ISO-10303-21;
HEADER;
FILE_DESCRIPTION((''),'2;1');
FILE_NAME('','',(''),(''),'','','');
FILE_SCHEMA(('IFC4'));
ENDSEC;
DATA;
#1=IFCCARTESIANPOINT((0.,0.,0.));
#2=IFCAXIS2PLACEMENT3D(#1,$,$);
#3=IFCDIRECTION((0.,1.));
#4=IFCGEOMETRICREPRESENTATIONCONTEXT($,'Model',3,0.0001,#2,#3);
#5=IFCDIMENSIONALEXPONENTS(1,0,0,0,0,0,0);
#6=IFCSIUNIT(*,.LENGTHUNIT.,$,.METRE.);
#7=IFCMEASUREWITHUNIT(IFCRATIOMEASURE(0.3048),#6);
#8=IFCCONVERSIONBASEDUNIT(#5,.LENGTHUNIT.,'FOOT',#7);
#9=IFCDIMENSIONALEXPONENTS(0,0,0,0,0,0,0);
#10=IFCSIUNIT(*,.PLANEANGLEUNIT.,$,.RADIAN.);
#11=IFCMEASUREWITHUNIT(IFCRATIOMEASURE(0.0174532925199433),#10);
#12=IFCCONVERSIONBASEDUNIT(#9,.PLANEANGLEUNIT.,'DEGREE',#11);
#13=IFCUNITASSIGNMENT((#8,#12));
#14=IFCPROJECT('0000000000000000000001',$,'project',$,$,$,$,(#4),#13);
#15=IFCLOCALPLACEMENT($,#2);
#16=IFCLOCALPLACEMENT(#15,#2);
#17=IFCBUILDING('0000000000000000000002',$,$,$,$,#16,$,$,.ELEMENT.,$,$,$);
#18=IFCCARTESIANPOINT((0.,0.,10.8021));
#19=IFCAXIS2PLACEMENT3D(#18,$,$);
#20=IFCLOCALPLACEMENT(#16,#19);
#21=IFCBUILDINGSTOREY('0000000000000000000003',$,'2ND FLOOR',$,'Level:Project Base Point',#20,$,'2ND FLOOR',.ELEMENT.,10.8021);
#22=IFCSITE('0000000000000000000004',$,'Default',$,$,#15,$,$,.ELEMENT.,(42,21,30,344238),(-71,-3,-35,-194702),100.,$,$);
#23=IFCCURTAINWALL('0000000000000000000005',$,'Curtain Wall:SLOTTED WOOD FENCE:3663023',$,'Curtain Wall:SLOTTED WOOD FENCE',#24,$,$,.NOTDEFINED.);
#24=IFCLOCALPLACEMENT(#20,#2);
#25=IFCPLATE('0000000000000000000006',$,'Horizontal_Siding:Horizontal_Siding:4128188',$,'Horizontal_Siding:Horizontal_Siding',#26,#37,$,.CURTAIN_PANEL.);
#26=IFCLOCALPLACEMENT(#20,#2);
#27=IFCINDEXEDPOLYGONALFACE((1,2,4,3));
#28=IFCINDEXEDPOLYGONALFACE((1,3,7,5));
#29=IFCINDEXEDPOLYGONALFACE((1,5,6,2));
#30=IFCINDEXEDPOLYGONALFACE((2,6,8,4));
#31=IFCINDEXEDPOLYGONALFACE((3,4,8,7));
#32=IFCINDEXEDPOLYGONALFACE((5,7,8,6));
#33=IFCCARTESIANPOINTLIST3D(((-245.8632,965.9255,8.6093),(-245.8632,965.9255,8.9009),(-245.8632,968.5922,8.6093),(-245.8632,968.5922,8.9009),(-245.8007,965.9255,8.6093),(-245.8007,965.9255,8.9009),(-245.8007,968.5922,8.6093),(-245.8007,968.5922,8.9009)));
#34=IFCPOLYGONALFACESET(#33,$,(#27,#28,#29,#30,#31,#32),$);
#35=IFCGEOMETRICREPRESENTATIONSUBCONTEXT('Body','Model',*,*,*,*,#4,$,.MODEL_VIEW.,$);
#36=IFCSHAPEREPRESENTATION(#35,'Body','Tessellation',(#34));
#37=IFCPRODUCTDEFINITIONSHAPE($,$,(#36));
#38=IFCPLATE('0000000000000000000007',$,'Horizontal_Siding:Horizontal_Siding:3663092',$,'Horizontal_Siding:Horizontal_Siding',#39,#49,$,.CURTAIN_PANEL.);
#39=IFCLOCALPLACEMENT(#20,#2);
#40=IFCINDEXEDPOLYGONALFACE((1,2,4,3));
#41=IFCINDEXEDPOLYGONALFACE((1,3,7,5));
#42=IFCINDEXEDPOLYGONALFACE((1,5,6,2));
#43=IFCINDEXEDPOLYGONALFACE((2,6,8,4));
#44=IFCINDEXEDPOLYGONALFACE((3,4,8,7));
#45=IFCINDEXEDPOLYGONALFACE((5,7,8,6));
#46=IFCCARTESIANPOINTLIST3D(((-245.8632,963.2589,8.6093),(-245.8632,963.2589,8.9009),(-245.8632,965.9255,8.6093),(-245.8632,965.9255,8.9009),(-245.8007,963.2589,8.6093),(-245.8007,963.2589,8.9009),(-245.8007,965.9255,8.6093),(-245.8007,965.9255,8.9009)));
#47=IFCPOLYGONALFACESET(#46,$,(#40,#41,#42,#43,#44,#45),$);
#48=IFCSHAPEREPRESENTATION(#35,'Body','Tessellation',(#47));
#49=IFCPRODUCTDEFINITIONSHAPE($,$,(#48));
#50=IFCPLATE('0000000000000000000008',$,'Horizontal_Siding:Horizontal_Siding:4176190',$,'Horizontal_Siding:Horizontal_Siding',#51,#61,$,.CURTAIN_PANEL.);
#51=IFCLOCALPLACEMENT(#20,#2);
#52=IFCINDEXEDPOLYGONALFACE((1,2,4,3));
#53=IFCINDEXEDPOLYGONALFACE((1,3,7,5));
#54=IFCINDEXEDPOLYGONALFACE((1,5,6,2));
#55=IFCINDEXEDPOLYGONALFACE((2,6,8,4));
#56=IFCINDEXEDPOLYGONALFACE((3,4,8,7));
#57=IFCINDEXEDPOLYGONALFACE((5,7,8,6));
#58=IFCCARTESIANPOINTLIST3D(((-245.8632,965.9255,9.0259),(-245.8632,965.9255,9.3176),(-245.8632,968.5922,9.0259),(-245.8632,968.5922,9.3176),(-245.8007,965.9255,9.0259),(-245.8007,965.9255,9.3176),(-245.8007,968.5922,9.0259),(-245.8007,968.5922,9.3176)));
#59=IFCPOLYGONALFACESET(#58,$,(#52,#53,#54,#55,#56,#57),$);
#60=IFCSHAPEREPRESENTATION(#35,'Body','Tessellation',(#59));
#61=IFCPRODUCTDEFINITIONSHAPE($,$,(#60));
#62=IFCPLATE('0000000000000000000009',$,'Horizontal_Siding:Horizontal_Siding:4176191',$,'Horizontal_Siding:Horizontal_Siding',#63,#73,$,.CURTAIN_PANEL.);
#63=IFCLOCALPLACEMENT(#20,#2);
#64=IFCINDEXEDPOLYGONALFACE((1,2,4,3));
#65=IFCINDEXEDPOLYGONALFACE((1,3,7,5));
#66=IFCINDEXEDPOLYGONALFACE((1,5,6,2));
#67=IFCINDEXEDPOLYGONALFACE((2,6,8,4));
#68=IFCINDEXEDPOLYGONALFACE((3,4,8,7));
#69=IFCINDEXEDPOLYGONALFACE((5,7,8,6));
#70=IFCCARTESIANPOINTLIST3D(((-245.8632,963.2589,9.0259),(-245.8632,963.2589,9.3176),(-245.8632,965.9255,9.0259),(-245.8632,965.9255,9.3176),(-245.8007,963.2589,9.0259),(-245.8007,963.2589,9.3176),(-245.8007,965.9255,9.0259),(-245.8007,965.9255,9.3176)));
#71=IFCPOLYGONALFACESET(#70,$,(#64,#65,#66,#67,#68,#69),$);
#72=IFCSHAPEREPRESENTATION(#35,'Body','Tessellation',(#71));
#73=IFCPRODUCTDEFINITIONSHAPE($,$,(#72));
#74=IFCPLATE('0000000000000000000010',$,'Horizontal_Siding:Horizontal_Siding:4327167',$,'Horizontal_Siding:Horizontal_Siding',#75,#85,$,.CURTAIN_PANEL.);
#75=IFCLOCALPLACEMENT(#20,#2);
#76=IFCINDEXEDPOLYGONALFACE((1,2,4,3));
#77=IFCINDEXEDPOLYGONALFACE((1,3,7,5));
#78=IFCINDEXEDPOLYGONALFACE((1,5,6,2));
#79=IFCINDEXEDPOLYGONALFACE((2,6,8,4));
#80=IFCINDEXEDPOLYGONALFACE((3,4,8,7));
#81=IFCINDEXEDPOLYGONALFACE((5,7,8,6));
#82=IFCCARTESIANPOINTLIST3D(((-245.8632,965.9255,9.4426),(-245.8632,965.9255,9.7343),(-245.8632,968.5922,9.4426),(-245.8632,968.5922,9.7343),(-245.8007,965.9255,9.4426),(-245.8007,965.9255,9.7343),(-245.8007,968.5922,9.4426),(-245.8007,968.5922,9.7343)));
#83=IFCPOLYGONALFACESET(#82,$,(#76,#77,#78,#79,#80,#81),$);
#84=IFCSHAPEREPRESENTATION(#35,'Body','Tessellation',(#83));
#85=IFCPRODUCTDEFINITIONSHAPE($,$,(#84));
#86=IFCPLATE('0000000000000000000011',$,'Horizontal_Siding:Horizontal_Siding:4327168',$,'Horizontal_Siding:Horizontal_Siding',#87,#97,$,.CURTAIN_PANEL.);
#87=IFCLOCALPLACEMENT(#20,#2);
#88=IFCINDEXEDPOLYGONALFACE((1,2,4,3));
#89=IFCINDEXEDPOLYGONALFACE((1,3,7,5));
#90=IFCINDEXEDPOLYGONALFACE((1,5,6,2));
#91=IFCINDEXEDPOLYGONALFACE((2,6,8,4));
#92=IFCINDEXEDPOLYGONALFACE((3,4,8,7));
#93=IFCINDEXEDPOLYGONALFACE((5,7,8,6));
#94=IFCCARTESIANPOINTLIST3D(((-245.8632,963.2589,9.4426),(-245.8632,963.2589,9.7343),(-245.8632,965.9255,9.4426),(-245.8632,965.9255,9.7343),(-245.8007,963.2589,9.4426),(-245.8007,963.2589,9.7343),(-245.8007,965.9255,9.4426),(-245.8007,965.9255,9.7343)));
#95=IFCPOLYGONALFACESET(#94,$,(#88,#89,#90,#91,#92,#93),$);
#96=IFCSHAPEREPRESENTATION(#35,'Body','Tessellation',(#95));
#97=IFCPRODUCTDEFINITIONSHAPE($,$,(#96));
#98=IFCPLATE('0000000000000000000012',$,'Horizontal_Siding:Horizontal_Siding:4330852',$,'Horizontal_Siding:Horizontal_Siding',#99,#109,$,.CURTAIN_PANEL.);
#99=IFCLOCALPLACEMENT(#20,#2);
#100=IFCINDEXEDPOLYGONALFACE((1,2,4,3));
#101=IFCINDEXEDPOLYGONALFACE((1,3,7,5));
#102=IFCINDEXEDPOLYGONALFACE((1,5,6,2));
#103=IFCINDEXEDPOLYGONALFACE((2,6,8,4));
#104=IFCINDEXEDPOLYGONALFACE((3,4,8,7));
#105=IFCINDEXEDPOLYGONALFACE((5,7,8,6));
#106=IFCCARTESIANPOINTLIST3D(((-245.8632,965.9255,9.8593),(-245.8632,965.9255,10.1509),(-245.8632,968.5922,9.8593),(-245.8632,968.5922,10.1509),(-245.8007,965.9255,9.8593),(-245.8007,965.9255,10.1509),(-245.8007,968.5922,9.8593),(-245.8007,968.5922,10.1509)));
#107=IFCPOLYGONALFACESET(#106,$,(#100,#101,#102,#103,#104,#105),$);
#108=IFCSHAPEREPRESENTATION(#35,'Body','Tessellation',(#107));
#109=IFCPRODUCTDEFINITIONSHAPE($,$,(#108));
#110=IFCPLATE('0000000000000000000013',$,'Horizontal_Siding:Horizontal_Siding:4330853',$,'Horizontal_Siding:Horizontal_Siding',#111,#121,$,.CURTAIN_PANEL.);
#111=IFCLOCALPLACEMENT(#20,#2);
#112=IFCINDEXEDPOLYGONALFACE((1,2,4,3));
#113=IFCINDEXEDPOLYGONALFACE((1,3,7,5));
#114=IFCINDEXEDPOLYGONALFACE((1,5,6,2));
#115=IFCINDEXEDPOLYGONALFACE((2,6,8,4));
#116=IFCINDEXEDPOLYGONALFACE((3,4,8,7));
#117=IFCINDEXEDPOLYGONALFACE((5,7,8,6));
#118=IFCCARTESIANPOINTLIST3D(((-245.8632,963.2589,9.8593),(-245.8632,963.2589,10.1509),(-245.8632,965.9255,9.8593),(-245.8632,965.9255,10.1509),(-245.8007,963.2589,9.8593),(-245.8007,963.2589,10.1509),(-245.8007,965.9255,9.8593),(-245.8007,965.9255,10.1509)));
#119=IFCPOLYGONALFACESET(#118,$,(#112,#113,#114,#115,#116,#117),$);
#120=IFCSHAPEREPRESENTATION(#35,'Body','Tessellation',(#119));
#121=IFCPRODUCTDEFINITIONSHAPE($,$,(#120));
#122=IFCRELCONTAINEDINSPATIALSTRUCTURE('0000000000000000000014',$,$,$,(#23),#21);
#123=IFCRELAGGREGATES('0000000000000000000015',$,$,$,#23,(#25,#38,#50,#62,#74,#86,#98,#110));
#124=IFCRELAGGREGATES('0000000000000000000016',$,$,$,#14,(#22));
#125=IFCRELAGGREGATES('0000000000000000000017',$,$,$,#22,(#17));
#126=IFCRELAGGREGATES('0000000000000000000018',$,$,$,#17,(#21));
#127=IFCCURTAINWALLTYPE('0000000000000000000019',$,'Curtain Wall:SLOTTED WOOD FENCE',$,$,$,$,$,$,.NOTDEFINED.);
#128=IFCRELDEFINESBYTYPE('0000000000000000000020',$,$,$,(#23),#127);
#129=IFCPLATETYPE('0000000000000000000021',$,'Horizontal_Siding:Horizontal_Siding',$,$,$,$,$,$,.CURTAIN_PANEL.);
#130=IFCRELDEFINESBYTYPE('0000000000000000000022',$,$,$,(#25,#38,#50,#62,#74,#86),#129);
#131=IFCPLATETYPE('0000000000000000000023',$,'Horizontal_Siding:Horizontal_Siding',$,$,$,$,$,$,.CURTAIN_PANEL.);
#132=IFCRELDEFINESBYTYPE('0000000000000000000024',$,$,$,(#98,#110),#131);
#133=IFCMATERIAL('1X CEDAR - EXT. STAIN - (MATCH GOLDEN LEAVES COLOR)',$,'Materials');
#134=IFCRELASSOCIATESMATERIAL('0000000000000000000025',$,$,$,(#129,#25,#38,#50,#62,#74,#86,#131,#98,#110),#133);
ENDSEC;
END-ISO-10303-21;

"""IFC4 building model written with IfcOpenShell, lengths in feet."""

from ifc_helpers import new_model, entity, si_unit, converted_unit, direction, frame, origin, origin_2d_with_axis, place, context, subcontext, project, spatial, rectangle, extrude, source, transform, mapped, material, type_object, type_shapes, element, aggregate, save


model = new_model("IFC4")

# Units and contexts
model_context = context("Model", 3, precision=0.0001, world=origin(), true_north=direction((0.0, 1.0)))
body_context = subcontext(model_context, "Body", "Model", "MODEL_VIEW")
ifc_project = project(units=[converted_unit("LENGTHUNIT", "FOOT", entity("IfcRatioMeasure", 0.3048), si_unit("LENGTHUNIT", "METRE"), dimensions=[1, 0, 0, 0, 0, 0, 0]), converted_unit("PLANEANGLEUNIT", "DEGREE", entity("IfcRatioMeasure", 0.0174532925199433), si_unit("PLANEANGLEUNIT", "RADIAN"), dimensions=[0, 0, 0, 0, 0, 0, 0])], contexts=[model_context])

# Site, building, storey
site_placement = place(None, origin())
site = spatial("IfcSite", under=ifc_project, at=site_placement, Name="Default", CompositionType="ELEMENT", RefLatitude=(42, 21, 30, 344238), RefLongitude=(-71, -3, -35, -194702), RefElevation=100.0)
building_placement = place(site_placement, origin())
building = spatial("IfcBuilding", under=site, at=building_placement, CompositionType="ELEMENT")
storey_placement = place(building_placement, frame((0.0, 0.0, 10.8021)))
storey = spatial("IfcBuildingStorey", under=building, at=storey_placement, Name="2ND FLOOR", ObjectType="Level:Project Base Point", LongName="2ND FLOOR", CompositionType="ELEMENT", Elevation=10.8021)

# Curtain wall, plates
curtain_wall_type = type_object("IfcCurtainWallType", Name="Curtain Wall:SLOTTED WOOD FENCE", PredefinedType="NOTDEFINED")
curtain_wall_placement = place(storey_placement, frame((0.0, 0.0, -10.8021)))
curtain_wall = element("IfcCurtainWall", 1, at=curtain_wall_placement, inside=storey, type_object=curtain_wall_type, Name="Curtain Wall:SLOTTED WOOD FENCE:3663023", ObjectType="Curtain Wall:SLOTTED WOOD FENCE", PredefinedType="NOTDEFINED")
ifc_material_1 = material(Name="1X CEDAR - EXT. STAIN - (MATCH GOLDEN LEAVES COLOR)", Category="Materials")
plate_type_1 = type_object("IfcPlateType", Name="Horizontal_Siding:Horizontal_Siding", PredefinedType="CURTAIN_PANEL", material=ifc_material_1)
shared_shape_1 = source(origin(), body_context, "Body", "SweptSolid", [
    extrude(rectangle(XDim=0.0625, YDim=2.6667, at=origin_2d_with_axis()), frame((1.3333, 0.0312, 0.0), z_axis=(0.0, 0.0, 1.0), x_axis=(0.0, 1.0, 0.0)), (0.0, 0.0, 1.0), 0.2917),
])
type_shapes(plate_type_1, [shared_shape_1])
plate_1_placement = place(curtain_wall_placement, frame((-245.8632, 968.5922, 19.4113), z_axis=(0.0, 0.0, 1.0), x_axis=(0.0, -1.0, 0.0)))
plate_1 = element("IfcPlate", 2, at=plate_1_placement, type_object=plate_type_1, material=ifc_material_1, Name="Horizontal_Siding:Horizontal_Siding:4128188", ObjectType="Horizontal_Siding:Horizontal_Siding", PredefinedType="CURTAIN_PANEL", context=body_context, shape_type="MappedRepresentation", body=[
    mapped(shared_shape_1, transform((0.0, 0.0, 0.0), scale=1.0)),
])
plate_2_placement = place(curtain_wall_placement, frame((-245.8632, 965.9255, 19.4113), z_axis=(0.0, 0.0, 1.0), x_axis=(0.0, -1.0, 0.0)))
plate_2 = element("IfcPlate", 3, at=plate_2_placement, type_object=plate_type_1, material=ifc_material_1, Name="Horizontal_Siding:Horizontal_Siding:3663092", ObjectType="Horizontal_Siding:Horizontal_Siding", PredefinedType="CURTAIN_PANEL", context=body_context, shape_type="MappedRepresentation", body=[
    mapped(shared_shape_1, transform((0.0, 0.0, 0.0), scale=1.0)),
])
plate_3_placement = place(curtain_wall_placement, frame((-245.8632, 968.5922, 19.828), z_axis=(0.0, 0.0, 1.0), x_axis=(0.0, -1.0, 0.0)))
plate_3 = element("IfcPlate", 4, at=plate_3_placement, type_object=plate_type_1, material=ifc_material_1, Name="Horizontal_Siding:Horizontal_Siding:4176190", ObjectType="Horizontal_Siding:Horizontal_Siding", PredefinedType="CURTAIN_PANEL", context=body_context, shape_type="MappedRepresentation", body=[
    mapped(shared_shape_1, transform((0.0, 0.0, 0.0), scale=1.0)),
])
plate_4_placement = place(curtain_wall_placement, frame((-245.8632, 965.9255, 19.828), z_axis=(0.0, 0.0, 1.0), x_axis=(0.0, -1.0, 0.0)))
plate_4 = element("IfcPlate", 5, at=plate_4_placement, type_object=plate_type_1, material=ifc_material_1, Name="Horizontal_Siding:Horizontal_Siding:4176191", ObjectType="Horizontal_Siding:Horizontal_Siding", PredefinedType="CURTAIN_PANEL", context=body_context, shape_type="MappedRepresentation", body=[
    mapped(shared_shape_1, transform((0.0, 0.0, 0.0), scale=1.0)),
])
plate_5_placement = place(curtain_wall_placement, frame((-245.8632, 968.5922, 20.2447), z_axis=(0.0, 0.0, 1.0), x_axis=(0.0, -1.0, 0.0)))
plate_5 = element("IfcPlate", 6, at=plate_5_placement, type_object=plate_type_1, material=ifc_material_1, Name="Horizontal_Siding:Horizontal_Siding:4327167", ObjectType="Horizontal_Siding:Horizontal_Siding", PredefinedType="CURTAIN_PANEL", context=body_context, shape_type="MappedRepresentation", body=[
    mapped(shared_shape_1, transform((0.0, 0.0, 0.0), scale=1.0)),
])
plate_6_placement = place(curtain_wall_placement, frame((-245.8632, 965.9255, 20.2447), z_axis=(0.0, 0.0, 1.0), x_axis=(0.0, -1.0, 0.0)))
plate_6 = element("IfcPlate", 7, at=plate_6_placement, type_object=plate_type_1, material=ifc_material_1, Name="Horizontal_Siding:Horizontal_Siding:4327168", ObjectType="Horizontal_Siding:Horizontal_Siding", PredefinedType="CURTAIN_PANEL", context=body_context, shape_type="MappedRepresentation", body=[
    mapped(shared_shape_1, transform((0.0, 0.0, 0.0), scale=1.0)),
])
plate_type_2 = type_object("IfcPlateType", Name="Horizontal_Siding:Horizontal_Siding", PredefinedType="CURTAIN_PANEL", material=ifc_material_1)
shared_shape_2 = source(origin(), body_context, "Body", "SweptSolid", [
    extrude(rectangle(XDim=0.0625, YDim=2.6667, at=origin_2d_with_axis()), frame((1.3333, 0.0312, 0.0), z_axis=(0.0, 0.0, 1.0), x_axis=(0.0, 1.0, 0.0)), (0.0, 0.0, 1.0), 0.2917),
])
type_shapes(plate_type_2, [shared_shape_2])
plate_7_placement = place(curtain_wall_placement, frame((-245.8632, 968.5922, 20.6613), z_axis=(0.0, 0.0, 1.0), x_axis=(0.0, -1.0, 0.0)))
plate_7 = element("IfcPlate", 8, at=plate_7_placement, type_object=plate_type_2, material=ifc_material_1, Name="Horizontal_Siding:Horizontal_Siding:4330852", ObjectType="Horizontal_Siding:Horizontal_Siding", PredefinedType="CURTAIN_PANEL", context=body_context, shape_type="MappedRepresentation", body=[
    mapped(shared_shape_2, transform((0.0, 0.0, 0.0), scale=1.0)),
])
plate_8_placement = place(curtain_wall_placement, frame((-245.8632, 965.9255, 20.6613), z_axis=(0.0, 0.0, 1.0), x_axis=(0.0, -1.0, 0.0)))
plate_8 = element("IfcPlate", 9, at=plate_8_placement, type_object=plate_type_2, material=ifc_material_1, Name="Horizontal_Siding:Horizontal_Siding:4330853", ObjectType="Horizontal_Siding:Horizontal_Siding", PredefinedType="CURTAIN_PANEL", context=body_context, shape_type="MappedRepresentation", body=[
    mapped(shared_shape_2, transform((0.0, 0.0, 0.0), scale=1.0)),
])
aggregate(curtain_wall, [plate_1, plate_2, plate_3, plate_4, plate_5, plate_6, plate_7, plate_8])

save(model, "model.ifc")
